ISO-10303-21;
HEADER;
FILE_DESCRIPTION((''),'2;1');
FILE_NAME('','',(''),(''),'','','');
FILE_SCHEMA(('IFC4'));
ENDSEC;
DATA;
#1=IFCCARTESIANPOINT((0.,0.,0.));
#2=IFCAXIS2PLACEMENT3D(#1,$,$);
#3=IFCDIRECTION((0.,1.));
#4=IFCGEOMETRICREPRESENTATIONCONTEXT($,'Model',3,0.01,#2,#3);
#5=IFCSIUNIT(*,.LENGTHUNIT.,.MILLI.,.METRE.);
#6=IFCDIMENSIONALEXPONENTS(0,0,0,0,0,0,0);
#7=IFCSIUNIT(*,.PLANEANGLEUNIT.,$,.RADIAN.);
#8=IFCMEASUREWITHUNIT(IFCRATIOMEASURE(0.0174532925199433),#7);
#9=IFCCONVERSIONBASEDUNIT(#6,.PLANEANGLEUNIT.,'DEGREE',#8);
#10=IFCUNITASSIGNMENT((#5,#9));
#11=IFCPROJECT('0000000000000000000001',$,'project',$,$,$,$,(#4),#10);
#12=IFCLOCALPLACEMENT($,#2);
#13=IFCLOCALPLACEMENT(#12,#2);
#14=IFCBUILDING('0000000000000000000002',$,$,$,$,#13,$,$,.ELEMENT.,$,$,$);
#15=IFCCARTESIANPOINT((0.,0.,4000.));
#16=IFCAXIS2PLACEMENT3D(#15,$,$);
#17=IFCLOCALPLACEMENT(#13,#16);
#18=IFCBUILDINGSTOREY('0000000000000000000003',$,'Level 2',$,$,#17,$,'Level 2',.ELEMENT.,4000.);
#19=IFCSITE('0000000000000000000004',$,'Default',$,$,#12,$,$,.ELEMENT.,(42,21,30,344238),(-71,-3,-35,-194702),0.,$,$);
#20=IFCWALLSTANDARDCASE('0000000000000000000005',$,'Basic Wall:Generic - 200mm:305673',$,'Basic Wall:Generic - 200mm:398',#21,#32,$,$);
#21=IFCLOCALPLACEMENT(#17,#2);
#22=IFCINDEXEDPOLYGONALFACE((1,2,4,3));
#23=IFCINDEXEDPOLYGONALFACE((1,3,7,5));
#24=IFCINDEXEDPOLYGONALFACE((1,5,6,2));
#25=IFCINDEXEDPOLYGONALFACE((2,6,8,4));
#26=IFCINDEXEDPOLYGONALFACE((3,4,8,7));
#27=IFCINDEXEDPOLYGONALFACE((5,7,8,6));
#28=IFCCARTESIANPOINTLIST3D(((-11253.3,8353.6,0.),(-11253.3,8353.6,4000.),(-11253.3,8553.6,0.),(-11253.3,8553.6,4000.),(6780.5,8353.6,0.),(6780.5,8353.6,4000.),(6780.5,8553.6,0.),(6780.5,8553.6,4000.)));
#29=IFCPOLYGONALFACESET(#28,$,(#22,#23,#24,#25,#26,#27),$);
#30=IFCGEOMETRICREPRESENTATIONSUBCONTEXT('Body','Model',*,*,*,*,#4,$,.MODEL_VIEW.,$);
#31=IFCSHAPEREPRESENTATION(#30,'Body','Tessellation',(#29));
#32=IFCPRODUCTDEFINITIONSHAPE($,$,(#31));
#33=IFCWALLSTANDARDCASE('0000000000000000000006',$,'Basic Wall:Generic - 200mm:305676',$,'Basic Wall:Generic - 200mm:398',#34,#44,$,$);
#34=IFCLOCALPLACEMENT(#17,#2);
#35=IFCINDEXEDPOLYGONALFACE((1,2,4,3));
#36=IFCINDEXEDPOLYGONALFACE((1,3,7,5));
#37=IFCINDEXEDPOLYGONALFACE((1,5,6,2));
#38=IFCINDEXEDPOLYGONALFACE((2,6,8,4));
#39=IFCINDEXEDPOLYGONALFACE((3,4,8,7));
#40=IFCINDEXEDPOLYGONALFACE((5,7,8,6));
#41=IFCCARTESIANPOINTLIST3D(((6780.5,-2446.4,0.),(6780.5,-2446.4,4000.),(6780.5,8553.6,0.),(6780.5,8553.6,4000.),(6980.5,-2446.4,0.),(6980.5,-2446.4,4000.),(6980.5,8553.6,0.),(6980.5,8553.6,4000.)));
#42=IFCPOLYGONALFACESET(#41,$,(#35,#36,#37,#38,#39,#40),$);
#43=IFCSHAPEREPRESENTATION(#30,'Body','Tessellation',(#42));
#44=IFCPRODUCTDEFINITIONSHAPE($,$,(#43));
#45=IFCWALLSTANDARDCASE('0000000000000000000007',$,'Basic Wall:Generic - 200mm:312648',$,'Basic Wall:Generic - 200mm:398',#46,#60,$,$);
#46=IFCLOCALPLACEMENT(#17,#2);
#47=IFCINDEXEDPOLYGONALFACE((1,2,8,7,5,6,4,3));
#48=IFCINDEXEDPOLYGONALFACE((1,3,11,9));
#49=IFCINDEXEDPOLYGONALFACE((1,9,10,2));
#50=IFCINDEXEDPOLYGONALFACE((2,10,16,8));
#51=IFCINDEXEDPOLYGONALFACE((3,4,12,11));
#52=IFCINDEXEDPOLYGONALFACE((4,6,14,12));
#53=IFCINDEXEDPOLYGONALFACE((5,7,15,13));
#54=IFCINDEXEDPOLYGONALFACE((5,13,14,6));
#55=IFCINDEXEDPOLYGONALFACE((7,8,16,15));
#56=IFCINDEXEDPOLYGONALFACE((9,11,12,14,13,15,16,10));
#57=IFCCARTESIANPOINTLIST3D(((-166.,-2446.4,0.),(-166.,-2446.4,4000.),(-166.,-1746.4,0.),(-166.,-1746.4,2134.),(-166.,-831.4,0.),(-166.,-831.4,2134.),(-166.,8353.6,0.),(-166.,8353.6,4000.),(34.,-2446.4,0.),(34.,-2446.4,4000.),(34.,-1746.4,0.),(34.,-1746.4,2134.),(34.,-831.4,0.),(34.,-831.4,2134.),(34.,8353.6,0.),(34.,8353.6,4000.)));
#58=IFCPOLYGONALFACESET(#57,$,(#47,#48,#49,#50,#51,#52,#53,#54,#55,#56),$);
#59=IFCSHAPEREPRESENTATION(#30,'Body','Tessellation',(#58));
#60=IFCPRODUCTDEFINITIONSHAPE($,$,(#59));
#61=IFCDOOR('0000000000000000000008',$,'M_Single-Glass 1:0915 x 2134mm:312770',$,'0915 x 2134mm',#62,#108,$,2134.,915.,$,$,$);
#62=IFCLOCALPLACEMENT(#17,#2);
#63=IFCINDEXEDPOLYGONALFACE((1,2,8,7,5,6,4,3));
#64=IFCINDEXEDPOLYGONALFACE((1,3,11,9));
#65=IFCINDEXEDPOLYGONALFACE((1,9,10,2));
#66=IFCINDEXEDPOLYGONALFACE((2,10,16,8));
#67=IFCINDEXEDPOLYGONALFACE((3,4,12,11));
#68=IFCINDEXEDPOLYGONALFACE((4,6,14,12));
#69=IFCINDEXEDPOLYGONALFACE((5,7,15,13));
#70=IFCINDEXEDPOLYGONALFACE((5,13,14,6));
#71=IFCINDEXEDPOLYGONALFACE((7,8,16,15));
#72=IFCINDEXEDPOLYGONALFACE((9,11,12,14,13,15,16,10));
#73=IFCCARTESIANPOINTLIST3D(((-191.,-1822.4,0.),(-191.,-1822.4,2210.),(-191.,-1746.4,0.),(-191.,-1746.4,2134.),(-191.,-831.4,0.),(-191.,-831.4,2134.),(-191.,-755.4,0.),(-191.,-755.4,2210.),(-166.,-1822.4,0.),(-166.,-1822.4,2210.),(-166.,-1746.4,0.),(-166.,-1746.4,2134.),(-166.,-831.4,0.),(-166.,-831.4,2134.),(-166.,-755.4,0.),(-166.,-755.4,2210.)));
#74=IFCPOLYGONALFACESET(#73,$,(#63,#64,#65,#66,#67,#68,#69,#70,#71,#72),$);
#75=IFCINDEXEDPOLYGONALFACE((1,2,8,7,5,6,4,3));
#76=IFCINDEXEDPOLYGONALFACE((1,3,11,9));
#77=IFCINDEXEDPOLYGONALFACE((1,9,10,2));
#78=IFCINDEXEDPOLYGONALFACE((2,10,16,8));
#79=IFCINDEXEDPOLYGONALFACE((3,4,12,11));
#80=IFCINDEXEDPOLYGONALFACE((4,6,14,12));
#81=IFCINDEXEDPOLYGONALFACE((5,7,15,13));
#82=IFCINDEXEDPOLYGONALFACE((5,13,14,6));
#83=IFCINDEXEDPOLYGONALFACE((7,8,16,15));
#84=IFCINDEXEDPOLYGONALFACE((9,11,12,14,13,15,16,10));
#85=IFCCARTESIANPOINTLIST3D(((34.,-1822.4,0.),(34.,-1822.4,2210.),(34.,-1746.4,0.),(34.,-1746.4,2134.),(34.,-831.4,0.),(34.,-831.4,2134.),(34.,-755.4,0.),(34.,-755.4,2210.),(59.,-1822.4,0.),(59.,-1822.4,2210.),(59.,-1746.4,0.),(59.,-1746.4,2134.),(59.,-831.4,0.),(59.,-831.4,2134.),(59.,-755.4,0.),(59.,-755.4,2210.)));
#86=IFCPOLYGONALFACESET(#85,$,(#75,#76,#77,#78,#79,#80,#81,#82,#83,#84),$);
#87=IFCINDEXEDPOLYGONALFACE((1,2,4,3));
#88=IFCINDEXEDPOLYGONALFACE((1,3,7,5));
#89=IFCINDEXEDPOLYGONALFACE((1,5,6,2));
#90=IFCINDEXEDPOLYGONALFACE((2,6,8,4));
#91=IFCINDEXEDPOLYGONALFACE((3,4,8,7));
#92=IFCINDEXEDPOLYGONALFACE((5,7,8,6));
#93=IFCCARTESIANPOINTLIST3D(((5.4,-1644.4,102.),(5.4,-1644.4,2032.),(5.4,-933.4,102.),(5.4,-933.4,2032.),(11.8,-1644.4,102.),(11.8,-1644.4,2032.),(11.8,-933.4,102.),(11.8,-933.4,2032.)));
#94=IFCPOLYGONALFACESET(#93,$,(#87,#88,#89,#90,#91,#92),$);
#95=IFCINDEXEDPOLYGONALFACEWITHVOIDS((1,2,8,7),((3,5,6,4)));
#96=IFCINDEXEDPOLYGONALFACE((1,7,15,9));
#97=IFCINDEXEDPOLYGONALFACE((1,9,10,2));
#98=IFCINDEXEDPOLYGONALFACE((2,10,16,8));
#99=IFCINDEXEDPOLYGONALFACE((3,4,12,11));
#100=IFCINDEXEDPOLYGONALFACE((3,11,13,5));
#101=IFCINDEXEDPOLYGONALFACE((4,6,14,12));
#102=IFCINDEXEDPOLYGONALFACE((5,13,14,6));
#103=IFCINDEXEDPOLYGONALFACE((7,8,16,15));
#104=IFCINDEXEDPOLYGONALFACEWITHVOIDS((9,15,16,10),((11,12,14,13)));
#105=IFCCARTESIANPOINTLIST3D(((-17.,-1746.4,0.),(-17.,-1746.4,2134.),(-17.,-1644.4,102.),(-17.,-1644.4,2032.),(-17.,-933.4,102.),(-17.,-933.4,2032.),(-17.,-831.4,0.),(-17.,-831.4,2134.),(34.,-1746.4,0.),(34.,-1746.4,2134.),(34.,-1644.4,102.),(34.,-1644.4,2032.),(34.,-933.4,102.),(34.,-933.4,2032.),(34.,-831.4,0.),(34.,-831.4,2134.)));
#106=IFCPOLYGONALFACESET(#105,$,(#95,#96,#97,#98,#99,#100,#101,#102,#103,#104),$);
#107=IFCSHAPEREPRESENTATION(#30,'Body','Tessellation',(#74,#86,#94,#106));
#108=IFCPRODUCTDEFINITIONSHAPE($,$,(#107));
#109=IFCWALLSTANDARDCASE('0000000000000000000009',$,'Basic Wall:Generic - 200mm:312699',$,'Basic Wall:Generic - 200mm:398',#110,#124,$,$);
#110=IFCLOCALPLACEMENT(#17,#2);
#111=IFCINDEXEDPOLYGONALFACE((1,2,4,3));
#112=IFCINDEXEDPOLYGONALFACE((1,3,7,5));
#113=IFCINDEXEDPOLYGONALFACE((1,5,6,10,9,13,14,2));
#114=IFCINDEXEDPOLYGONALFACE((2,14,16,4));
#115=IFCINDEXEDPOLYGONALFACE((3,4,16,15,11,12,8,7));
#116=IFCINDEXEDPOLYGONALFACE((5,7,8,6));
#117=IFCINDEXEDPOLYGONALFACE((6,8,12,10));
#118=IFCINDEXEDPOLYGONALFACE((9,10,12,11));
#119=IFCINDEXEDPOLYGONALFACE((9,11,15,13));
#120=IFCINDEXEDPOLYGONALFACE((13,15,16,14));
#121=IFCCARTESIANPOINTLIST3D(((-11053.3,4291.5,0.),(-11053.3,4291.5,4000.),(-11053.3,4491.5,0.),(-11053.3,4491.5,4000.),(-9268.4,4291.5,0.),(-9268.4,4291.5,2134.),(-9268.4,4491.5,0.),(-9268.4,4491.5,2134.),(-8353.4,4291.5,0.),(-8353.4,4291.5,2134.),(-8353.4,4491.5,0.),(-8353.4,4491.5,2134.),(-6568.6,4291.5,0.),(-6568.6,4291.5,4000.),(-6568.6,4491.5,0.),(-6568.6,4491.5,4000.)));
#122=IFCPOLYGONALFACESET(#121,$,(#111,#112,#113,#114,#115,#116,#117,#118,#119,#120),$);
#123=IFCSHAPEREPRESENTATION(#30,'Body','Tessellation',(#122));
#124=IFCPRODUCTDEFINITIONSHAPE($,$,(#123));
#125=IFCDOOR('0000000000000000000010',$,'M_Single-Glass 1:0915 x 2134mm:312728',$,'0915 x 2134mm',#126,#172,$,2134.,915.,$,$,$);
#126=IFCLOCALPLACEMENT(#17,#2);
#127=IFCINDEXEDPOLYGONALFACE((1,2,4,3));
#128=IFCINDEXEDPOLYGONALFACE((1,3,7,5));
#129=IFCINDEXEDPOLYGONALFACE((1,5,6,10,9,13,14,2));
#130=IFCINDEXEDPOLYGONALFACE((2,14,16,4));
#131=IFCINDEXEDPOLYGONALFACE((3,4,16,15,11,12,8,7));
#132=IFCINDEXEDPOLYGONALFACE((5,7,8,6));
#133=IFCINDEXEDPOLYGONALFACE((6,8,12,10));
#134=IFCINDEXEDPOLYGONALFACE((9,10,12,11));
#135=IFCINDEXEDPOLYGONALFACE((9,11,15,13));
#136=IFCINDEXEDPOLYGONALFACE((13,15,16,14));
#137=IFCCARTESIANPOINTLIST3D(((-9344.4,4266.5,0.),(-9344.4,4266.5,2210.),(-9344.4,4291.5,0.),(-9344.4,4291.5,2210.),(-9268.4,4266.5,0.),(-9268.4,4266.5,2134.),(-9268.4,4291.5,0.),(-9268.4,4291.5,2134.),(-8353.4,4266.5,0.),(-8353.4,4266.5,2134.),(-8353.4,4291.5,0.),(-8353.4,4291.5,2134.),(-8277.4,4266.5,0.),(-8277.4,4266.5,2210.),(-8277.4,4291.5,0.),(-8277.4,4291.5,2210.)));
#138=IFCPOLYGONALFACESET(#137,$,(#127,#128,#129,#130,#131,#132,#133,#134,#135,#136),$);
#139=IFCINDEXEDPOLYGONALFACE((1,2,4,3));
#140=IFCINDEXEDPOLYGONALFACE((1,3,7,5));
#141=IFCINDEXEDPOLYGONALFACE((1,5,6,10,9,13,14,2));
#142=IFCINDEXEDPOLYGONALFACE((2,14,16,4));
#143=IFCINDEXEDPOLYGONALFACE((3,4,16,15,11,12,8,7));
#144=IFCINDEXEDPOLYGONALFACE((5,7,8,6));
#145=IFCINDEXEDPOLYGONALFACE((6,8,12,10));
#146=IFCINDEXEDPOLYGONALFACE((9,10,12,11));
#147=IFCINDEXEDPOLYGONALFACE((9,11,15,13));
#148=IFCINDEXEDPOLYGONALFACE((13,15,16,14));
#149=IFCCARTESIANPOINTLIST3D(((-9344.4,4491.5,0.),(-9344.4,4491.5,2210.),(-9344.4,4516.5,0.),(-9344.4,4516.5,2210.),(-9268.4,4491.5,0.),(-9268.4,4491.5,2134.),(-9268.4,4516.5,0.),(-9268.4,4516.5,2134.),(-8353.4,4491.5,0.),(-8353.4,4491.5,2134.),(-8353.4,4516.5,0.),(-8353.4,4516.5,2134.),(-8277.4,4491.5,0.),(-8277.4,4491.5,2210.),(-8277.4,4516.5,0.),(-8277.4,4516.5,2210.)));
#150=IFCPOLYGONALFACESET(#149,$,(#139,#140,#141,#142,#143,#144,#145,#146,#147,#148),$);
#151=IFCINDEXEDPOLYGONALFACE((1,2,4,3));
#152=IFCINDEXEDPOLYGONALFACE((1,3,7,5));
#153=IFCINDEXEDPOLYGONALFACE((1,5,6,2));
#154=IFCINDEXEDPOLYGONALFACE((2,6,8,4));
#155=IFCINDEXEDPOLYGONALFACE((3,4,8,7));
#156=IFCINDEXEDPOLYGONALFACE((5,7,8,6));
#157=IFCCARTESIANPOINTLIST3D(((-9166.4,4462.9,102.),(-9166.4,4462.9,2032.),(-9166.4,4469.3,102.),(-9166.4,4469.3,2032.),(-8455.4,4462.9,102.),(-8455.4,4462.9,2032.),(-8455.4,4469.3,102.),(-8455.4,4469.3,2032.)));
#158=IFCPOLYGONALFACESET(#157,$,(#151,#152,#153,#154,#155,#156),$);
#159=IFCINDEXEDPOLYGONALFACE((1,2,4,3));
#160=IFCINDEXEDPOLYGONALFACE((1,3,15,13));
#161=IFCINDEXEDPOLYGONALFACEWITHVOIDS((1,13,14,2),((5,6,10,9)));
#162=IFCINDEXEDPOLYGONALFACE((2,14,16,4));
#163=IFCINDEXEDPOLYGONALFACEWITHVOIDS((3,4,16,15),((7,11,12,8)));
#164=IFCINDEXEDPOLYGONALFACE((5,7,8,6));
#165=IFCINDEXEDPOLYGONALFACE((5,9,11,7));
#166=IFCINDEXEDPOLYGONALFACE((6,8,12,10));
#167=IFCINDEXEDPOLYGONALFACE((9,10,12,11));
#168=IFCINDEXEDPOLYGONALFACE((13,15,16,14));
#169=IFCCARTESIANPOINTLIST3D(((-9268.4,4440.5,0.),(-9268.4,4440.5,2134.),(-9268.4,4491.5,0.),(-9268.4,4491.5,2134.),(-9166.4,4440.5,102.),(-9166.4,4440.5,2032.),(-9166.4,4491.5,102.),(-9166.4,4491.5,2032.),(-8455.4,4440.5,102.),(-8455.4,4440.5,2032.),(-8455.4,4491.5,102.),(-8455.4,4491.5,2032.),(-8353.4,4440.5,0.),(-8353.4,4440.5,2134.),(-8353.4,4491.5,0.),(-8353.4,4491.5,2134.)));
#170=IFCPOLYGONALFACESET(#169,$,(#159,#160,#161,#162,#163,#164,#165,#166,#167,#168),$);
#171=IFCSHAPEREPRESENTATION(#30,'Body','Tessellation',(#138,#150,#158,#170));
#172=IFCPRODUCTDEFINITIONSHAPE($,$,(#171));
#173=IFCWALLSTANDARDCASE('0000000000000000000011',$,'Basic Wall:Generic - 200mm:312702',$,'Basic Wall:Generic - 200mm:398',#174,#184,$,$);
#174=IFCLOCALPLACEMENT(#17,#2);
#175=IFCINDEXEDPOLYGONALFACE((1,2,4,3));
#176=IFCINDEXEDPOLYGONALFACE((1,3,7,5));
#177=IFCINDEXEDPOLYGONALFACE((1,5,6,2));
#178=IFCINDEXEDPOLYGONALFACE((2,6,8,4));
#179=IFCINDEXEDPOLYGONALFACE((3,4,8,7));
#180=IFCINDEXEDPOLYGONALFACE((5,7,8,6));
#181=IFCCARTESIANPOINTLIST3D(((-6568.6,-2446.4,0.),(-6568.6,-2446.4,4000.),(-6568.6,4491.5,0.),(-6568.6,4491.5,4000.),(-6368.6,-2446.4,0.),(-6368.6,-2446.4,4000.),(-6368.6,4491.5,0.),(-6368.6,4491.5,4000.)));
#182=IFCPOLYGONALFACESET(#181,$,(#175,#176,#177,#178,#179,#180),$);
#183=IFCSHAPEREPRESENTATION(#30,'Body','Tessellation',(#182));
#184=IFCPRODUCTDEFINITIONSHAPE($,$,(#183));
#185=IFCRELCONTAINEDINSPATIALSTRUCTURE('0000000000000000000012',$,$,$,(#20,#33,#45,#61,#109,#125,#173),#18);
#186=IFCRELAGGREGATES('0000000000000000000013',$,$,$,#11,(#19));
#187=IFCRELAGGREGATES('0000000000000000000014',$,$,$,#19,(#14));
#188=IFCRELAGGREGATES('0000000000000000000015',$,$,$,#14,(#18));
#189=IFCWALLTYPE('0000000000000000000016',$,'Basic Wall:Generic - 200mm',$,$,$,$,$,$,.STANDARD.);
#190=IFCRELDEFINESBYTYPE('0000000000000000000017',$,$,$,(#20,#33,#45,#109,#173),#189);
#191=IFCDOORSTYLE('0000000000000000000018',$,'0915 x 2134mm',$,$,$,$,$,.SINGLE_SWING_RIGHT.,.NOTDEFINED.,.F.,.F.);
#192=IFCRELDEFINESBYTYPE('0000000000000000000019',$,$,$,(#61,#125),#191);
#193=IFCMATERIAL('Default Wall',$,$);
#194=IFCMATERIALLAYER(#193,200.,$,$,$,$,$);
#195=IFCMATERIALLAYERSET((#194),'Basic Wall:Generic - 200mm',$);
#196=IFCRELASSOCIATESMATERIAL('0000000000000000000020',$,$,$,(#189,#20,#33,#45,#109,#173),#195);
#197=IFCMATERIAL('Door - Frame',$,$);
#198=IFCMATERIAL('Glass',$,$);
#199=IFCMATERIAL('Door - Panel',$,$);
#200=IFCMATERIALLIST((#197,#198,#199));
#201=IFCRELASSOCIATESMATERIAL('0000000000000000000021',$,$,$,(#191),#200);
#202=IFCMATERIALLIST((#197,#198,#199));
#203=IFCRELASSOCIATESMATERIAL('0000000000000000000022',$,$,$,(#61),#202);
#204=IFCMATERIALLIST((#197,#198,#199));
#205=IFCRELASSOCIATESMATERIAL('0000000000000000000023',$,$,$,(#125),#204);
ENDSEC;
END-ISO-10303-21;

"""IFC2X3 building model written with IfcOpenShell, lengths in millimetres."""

from ifc_helpers import new_model, entity, si_unit, converted_unit, direction, frame, frame_2d, origin, place, context, subcontext, project, spatial, polyline, rectangle, outline, extrude, clip, halfspace, source, transform, mapped, material, material_list, layer, layer_set, layer_usage, type_object, type_shapes, element, fill, save


model = new_model("IFC2X3")

# Units and contexts
model_context = context("Model", 3, precision=0.01, world=origin(), true_north=direction((0.0, 1.0)))
body_context = subcontext(model_context, "Body", "Model", "MODEL_VIEW")
ifc_project = project(units=[si_unit("LENGTHUNIT", "METRE", prefix="MILLI"), converted_unit("PLANEANGLEUNIT", "DEGREE", entity("IfcRatioMeasure", 0.0174532925199433), si_unit("PLANEANGLEUNIT", "RADIAN"), dimensions=[0, 0, 0, 0, 0, 0, 0])], contexts=[model_context])

# Site, building, storey
site_placement = place(None, origin())
site = spatial("IfcSite", under=ifc_project, at=site_placement, Name="Default", CompositionType="ELEMENT", RefLatitude=(42, 21, 30, 344238), RefLongitude=(-71, -3, -35, -194702), RefElevation=0.0)
building_placement = place(site_placement, origin())
building = spatial("IfcBuilding", under=site, at=building_placement, CompositionType="ELEMENT")
storey_placement = place(building_placement, frame((0.0, 0.0, 4000.0)))
storey = spatial("IfcBuildingStorey", under=building, at=storey_placement, Name="Level 2", LongName="Level 2", CompositionType="ELEMENT", Elevation=4000.0)

# Wall
ifc_material_1 = material(Name="Default Wall")
ifc_layer_1 = layer(ifc_material_1, 200.0)
ifc_layer_set_1 = layer_set([ifc_layer_1], Name="Basic Wall:Generic - 200mm")
ifc_layer_usage_1 = layer_usage(ifc_layer_set_1, "AXIS2", "NEGATIVE", 100.0)
wall_type = type_object("IfcWallType", Name="Basic Wall:Generic - 200mm", PredefinedType="STANDARD", material=ifc_layer_set_1)
wall_1_placement = place(storey_placement, frame((-11253.3, 8453.6, 0.0)))
element("IfcWallStandardCase", 1, at=wall_1_placement, inside=storey, type_object=wall_type, material=ifc_layer_usage_1, Name="Basic Wall:Generic - 200mm:305673", ObjectType="Basic Wall:Generic - 200mm:398", context=body_context, shape_type="Clipping", body=[
    clip(extrude(rectangle(XDim=18033.8, YDim=200.0, at=frame_2d((9016.9, 0.0), x_axis=(-1.0, 0.0))), origin(), (0.0, 0.0, 1.0), 4000.0), halfspace(frame((0.0, 0.0, -4000.0)), True)),
])

# Shared definitions
ifc_material_2 = material(Name="Glass")

# Wall
ifc_layer_usage_2 = layer_usage(ifc_layer_set_1, "AXIS2", "NEGATIVE", 100.0)
wall_2_placement = place(storey_placement, frame((6880.5, 8553.6, 0.0), z_axis=(0.0, 0.0, 1.0), x_axis=(0.0, -1.0, 0.0)))
element("IfcWallStandardCase", 2, at=wall_2_placement, inside=storey, type_object=wall_type, material=ifc_layer_usage_2, Name="Basic Wall:Generic - 200mm:305676", ObjectType="Basic Wall:Generic - 200mm:398", context=body_context, shape_type="Clipping", body=[
    clip(extrude(rectangle(XDim=11000.0, YDim=200.0, at=frame_2d((5500.0, 0.0), x_axis=(-1.0, 0.0))), origin(), (0.0, 0.0, 1.0), 4000.0), halfspace(frame((0.0, 0.0, -4000.0)), True)),
])

# Walls, openings, doors
ifc_layer_usage_3 = layer_usage(ifc_layer_set_1, "AXIS2", "NEGATIVE", 100.0)
wall_3_placement = place(storey_placement, frame((-66.0, 8353.6, 0.0), z_axis=(0.0, 0.0, 1.0), x_axis=(0.0, -1.0, 0.0)))
wall_3 = element("IfcWallStandardCase", 3, at=wall_3_placement, inside=storey, type_object=wall_type, material=ifc_layer_usage_3, Name="Basic Wall:Generic - 200mm:312648", ObjectType="Basic Wall:Generic - 200mm:398", context=body_context, shape_type="SweptSolid", body=[
    extrude(rectangle(XDim=10800.0, YDim=200.0, at=frame_2d((5400.0, 0.0), x_axis=(-1.0, 0.0))), origin(), (0.0, 0.0, 1.0), 4000.0),
])
opening_1_placement = place(wall_3_placement, frame((9185.0, -100.0, 0.0)))
opening_1 = element("IfcOpeningElement", 4, at=opening_1_placement, cuts=wall_3, ObjectType="Opening", context=body_context, shape_type="SweptSolid", body=[
    extrude(rectangle(XDim=915.0, YDim=2134.0, at=frame_2d((1067.0, 457.5), x_axis=(0.0, 1.0))), frame((0.0, 0.0, 0.0), z_axis=(0.0, 1.0, 0.0), x_axis=(0.0, 0.0, 1.0)), (0.0, 0.0, 1.0), 200.0),
])
ifc_material_3 = material(Name="Door - Frame")
ifc_material_4 = material(Name="Door - Panel")
ifc_material_list_1 = material_list([ifc_material_3, ifc_material_2, ifc_material_4])
ifc_material_list_2 = material_list([ifc_material_3, ifc_material_2, ifc_material_4])
door_style = type_object("IfcDoorStyle", Name="0915 x 2134mm", ConstructionType="NOTDEFINED", OperationType="SINGLE_SWING_RIGHT", ParameterTakesPrecedence=False, Sizeable=False, material=ifc_material_list_2)
shared_shape_1 = source(origin(), body_context, "Body", "SweptSolid", [
    extrude(outline(polyline([(-457.5, -1048.0), (-457.5, 1086.0), (-533.5, 1086.0), (-533.5, -1124.0), (533.5, -1124.0), (533.5, 1086.0), (457.5, 1086.0), (457.5, -1048.0), (-457.5, -1048.0)])), frame((457.5, -25.0, 1086.0), z_axis=(0.0, -1.0, 0.0), x_axis=(-1.0, 0.0, 0.0)), (0.0, 0.0, -1.0), 25.0),
    extrude(outline(polyline([(-457.5, -1048.0), (-457.5, 1086.0), (-533.5, 1086.0), (-533.5, -1124.0), (533.5, -1124.0), (533.5, 1086.0), (457.5, 1086.0), (457.5, -1048.0), (-457.5, -1048.0)])), frame((457.5, 200.0, 1086.0), z_axis=(0.0, -1.0, 0.0), x_axis=(-1.0, 0.0, 0.0)), (0.0, 0.0, -1.0), 25.0),
    extrude(rectangle(XDim=6.3, YDim=711.0, at=frame_2d((0.0, 0.0), x_axis=(1.0, 0.0))), frame((457.5, 174.6, 102.0), z_axis=(0.0, 0.0, 1.0), x_axis=(0.0, 1.0, 0.0)), (0.0, 0.0, 1.0), 1930.0),
    extrude(outline(polyline([(-1067.0, -457.5), (1067.0, -457.5), (1067.0, 457.5), (-1067.0, 457.5), (-1067.0, -457.5)]), holes=[polyline([(-965.0, 355.5), (965.0, 355.5), (965.0, -355.5), (-965.0, -355.5), (-965.0, 355.5)])]), frame((457.5, 149.0, 1067.0), z_axis=(0.0, 1.0, 0.0), x_axis=(0.0, 0.0, -1.0)), (0.0, 0.0, 1.0), 51.0),
])
type_shapes(door_style, [shared_shape_1])
door_1_placement = place(opening_1_placement, origin())
door_1 = element("IfcDoor", 5, at=door_1_placement, inside=storey, type_object=door_style, material=ifc_material_list_1, Name="M_Single-Glass 1:0915 x 2134mm:312770", ObjectType="0915 x 2134mm", OverallHeight=2134.0, OverallWidth=915.0, context=body_context, shape_type="MappedRepresentation", body=[
    mapped(shared_shape_1, transform((0.0, 0.0, 0.0), scale=1.0)),
])
fill(opening_1, door_1)
ifc_layer_usage_4 = layer_usage(ifc_layer_set_1, "AXIS2", "NEGATIVE", 100.0)
wall_4_placement = place(storey_placement, frame((-11053.3, 4391.5, 0.0)))
wall_4 = element("IfcWallStandardCase", 6, at=wall_4_placement, inside=storey, type_object=wall_type, material=ifc_layer_usage_4, Name="Basic Wall:Generic - 200mm:312699", ObjectType="Basic Wall:Generic - 200mm:398", context=body_context, shape_type="SweptSolid", body=[
    extrude(rectangle(XDim=4484.7, YDim=200.0, at=frame_2d((2242.3, 0.0), x_axis=(-1.0, 0.0))), origin(), (0.0, 0.0, 1.0), 4000.0),
])
opening_2_placement = place(wall_4_placement, frame((1784.8, -100.0, 0.0)))
opening_2 = element("IfcOpeningElement", 7, at=opening_2_placement, cuts=wall_4, ObjectType="Opening", context=body_context, shape_type="SweptSolid", body=[
    extrude(rectangle(XDim=915.0, YDim=2134.0, at=frame_2d((1067.0, 457.5), x_axis=(0.0, 1.0))), frame((0.0, 0.0, 0.0), z_axis=(0.0, 1.0, 0.0), x_axis=(0.0, 0.0, 1.0)), (0.0, 0.0, 1.0), 200.0),
])
ifc_material_list_3 = material_list([ifc_material_3, ifc_material_2, ifc_material_4])
door_2_placement = place(opening_2_placement, origin())
door_2 = element("IfcDoor", 8, at=door_2_placement, inside=storey, type_object=door_style, material=ifc_material_list_3, Name="M_Single-Glass 1:0915 x 2134mm:312728", ObjectType="0915 x 2134mm", OverallHeight=2134.0, OverallWidth=915.0, context=body_context, shape_type="MappedRepresentation", body=[
    mapped(shared_shape_1, transform((0.0, 0.0, 0.0), scale=1.0)),
])
fill(opening_2, door_2)

# Wall
ifc_layer_usage_5 = layer_usage(ifc_layer_set_1, "AXIS2", "NEGATIVE", 100.0)
wall_5_placement = place(storey_placement, frame((-6468.6, 4491.5, 0.0), z_axis=(0.0, 0.0, 1.0), x_axis=(0.0, -1.0, 0.0)))
element("IfcWallStandardCase", 9, at=wall_5_placement, inside=storey, type_object=wall_type, material=ifc_layer_usage_5, Name="Basic Wall:Generic - 200mm:312702", ObjectType="Basic Wall:Generic - 200mm:398", context=body_context, shape_type="SweptSolid", body=[
    extrude(rectangle(XDim=6937.9, YDim=200.0, at=frame_2d((3468.9, 0.0), x_axis=(-1.0, 0.0))), origin(), (0.0, 0.0, 1.0), 4000.0),
])

save(model, "model.ifc")
